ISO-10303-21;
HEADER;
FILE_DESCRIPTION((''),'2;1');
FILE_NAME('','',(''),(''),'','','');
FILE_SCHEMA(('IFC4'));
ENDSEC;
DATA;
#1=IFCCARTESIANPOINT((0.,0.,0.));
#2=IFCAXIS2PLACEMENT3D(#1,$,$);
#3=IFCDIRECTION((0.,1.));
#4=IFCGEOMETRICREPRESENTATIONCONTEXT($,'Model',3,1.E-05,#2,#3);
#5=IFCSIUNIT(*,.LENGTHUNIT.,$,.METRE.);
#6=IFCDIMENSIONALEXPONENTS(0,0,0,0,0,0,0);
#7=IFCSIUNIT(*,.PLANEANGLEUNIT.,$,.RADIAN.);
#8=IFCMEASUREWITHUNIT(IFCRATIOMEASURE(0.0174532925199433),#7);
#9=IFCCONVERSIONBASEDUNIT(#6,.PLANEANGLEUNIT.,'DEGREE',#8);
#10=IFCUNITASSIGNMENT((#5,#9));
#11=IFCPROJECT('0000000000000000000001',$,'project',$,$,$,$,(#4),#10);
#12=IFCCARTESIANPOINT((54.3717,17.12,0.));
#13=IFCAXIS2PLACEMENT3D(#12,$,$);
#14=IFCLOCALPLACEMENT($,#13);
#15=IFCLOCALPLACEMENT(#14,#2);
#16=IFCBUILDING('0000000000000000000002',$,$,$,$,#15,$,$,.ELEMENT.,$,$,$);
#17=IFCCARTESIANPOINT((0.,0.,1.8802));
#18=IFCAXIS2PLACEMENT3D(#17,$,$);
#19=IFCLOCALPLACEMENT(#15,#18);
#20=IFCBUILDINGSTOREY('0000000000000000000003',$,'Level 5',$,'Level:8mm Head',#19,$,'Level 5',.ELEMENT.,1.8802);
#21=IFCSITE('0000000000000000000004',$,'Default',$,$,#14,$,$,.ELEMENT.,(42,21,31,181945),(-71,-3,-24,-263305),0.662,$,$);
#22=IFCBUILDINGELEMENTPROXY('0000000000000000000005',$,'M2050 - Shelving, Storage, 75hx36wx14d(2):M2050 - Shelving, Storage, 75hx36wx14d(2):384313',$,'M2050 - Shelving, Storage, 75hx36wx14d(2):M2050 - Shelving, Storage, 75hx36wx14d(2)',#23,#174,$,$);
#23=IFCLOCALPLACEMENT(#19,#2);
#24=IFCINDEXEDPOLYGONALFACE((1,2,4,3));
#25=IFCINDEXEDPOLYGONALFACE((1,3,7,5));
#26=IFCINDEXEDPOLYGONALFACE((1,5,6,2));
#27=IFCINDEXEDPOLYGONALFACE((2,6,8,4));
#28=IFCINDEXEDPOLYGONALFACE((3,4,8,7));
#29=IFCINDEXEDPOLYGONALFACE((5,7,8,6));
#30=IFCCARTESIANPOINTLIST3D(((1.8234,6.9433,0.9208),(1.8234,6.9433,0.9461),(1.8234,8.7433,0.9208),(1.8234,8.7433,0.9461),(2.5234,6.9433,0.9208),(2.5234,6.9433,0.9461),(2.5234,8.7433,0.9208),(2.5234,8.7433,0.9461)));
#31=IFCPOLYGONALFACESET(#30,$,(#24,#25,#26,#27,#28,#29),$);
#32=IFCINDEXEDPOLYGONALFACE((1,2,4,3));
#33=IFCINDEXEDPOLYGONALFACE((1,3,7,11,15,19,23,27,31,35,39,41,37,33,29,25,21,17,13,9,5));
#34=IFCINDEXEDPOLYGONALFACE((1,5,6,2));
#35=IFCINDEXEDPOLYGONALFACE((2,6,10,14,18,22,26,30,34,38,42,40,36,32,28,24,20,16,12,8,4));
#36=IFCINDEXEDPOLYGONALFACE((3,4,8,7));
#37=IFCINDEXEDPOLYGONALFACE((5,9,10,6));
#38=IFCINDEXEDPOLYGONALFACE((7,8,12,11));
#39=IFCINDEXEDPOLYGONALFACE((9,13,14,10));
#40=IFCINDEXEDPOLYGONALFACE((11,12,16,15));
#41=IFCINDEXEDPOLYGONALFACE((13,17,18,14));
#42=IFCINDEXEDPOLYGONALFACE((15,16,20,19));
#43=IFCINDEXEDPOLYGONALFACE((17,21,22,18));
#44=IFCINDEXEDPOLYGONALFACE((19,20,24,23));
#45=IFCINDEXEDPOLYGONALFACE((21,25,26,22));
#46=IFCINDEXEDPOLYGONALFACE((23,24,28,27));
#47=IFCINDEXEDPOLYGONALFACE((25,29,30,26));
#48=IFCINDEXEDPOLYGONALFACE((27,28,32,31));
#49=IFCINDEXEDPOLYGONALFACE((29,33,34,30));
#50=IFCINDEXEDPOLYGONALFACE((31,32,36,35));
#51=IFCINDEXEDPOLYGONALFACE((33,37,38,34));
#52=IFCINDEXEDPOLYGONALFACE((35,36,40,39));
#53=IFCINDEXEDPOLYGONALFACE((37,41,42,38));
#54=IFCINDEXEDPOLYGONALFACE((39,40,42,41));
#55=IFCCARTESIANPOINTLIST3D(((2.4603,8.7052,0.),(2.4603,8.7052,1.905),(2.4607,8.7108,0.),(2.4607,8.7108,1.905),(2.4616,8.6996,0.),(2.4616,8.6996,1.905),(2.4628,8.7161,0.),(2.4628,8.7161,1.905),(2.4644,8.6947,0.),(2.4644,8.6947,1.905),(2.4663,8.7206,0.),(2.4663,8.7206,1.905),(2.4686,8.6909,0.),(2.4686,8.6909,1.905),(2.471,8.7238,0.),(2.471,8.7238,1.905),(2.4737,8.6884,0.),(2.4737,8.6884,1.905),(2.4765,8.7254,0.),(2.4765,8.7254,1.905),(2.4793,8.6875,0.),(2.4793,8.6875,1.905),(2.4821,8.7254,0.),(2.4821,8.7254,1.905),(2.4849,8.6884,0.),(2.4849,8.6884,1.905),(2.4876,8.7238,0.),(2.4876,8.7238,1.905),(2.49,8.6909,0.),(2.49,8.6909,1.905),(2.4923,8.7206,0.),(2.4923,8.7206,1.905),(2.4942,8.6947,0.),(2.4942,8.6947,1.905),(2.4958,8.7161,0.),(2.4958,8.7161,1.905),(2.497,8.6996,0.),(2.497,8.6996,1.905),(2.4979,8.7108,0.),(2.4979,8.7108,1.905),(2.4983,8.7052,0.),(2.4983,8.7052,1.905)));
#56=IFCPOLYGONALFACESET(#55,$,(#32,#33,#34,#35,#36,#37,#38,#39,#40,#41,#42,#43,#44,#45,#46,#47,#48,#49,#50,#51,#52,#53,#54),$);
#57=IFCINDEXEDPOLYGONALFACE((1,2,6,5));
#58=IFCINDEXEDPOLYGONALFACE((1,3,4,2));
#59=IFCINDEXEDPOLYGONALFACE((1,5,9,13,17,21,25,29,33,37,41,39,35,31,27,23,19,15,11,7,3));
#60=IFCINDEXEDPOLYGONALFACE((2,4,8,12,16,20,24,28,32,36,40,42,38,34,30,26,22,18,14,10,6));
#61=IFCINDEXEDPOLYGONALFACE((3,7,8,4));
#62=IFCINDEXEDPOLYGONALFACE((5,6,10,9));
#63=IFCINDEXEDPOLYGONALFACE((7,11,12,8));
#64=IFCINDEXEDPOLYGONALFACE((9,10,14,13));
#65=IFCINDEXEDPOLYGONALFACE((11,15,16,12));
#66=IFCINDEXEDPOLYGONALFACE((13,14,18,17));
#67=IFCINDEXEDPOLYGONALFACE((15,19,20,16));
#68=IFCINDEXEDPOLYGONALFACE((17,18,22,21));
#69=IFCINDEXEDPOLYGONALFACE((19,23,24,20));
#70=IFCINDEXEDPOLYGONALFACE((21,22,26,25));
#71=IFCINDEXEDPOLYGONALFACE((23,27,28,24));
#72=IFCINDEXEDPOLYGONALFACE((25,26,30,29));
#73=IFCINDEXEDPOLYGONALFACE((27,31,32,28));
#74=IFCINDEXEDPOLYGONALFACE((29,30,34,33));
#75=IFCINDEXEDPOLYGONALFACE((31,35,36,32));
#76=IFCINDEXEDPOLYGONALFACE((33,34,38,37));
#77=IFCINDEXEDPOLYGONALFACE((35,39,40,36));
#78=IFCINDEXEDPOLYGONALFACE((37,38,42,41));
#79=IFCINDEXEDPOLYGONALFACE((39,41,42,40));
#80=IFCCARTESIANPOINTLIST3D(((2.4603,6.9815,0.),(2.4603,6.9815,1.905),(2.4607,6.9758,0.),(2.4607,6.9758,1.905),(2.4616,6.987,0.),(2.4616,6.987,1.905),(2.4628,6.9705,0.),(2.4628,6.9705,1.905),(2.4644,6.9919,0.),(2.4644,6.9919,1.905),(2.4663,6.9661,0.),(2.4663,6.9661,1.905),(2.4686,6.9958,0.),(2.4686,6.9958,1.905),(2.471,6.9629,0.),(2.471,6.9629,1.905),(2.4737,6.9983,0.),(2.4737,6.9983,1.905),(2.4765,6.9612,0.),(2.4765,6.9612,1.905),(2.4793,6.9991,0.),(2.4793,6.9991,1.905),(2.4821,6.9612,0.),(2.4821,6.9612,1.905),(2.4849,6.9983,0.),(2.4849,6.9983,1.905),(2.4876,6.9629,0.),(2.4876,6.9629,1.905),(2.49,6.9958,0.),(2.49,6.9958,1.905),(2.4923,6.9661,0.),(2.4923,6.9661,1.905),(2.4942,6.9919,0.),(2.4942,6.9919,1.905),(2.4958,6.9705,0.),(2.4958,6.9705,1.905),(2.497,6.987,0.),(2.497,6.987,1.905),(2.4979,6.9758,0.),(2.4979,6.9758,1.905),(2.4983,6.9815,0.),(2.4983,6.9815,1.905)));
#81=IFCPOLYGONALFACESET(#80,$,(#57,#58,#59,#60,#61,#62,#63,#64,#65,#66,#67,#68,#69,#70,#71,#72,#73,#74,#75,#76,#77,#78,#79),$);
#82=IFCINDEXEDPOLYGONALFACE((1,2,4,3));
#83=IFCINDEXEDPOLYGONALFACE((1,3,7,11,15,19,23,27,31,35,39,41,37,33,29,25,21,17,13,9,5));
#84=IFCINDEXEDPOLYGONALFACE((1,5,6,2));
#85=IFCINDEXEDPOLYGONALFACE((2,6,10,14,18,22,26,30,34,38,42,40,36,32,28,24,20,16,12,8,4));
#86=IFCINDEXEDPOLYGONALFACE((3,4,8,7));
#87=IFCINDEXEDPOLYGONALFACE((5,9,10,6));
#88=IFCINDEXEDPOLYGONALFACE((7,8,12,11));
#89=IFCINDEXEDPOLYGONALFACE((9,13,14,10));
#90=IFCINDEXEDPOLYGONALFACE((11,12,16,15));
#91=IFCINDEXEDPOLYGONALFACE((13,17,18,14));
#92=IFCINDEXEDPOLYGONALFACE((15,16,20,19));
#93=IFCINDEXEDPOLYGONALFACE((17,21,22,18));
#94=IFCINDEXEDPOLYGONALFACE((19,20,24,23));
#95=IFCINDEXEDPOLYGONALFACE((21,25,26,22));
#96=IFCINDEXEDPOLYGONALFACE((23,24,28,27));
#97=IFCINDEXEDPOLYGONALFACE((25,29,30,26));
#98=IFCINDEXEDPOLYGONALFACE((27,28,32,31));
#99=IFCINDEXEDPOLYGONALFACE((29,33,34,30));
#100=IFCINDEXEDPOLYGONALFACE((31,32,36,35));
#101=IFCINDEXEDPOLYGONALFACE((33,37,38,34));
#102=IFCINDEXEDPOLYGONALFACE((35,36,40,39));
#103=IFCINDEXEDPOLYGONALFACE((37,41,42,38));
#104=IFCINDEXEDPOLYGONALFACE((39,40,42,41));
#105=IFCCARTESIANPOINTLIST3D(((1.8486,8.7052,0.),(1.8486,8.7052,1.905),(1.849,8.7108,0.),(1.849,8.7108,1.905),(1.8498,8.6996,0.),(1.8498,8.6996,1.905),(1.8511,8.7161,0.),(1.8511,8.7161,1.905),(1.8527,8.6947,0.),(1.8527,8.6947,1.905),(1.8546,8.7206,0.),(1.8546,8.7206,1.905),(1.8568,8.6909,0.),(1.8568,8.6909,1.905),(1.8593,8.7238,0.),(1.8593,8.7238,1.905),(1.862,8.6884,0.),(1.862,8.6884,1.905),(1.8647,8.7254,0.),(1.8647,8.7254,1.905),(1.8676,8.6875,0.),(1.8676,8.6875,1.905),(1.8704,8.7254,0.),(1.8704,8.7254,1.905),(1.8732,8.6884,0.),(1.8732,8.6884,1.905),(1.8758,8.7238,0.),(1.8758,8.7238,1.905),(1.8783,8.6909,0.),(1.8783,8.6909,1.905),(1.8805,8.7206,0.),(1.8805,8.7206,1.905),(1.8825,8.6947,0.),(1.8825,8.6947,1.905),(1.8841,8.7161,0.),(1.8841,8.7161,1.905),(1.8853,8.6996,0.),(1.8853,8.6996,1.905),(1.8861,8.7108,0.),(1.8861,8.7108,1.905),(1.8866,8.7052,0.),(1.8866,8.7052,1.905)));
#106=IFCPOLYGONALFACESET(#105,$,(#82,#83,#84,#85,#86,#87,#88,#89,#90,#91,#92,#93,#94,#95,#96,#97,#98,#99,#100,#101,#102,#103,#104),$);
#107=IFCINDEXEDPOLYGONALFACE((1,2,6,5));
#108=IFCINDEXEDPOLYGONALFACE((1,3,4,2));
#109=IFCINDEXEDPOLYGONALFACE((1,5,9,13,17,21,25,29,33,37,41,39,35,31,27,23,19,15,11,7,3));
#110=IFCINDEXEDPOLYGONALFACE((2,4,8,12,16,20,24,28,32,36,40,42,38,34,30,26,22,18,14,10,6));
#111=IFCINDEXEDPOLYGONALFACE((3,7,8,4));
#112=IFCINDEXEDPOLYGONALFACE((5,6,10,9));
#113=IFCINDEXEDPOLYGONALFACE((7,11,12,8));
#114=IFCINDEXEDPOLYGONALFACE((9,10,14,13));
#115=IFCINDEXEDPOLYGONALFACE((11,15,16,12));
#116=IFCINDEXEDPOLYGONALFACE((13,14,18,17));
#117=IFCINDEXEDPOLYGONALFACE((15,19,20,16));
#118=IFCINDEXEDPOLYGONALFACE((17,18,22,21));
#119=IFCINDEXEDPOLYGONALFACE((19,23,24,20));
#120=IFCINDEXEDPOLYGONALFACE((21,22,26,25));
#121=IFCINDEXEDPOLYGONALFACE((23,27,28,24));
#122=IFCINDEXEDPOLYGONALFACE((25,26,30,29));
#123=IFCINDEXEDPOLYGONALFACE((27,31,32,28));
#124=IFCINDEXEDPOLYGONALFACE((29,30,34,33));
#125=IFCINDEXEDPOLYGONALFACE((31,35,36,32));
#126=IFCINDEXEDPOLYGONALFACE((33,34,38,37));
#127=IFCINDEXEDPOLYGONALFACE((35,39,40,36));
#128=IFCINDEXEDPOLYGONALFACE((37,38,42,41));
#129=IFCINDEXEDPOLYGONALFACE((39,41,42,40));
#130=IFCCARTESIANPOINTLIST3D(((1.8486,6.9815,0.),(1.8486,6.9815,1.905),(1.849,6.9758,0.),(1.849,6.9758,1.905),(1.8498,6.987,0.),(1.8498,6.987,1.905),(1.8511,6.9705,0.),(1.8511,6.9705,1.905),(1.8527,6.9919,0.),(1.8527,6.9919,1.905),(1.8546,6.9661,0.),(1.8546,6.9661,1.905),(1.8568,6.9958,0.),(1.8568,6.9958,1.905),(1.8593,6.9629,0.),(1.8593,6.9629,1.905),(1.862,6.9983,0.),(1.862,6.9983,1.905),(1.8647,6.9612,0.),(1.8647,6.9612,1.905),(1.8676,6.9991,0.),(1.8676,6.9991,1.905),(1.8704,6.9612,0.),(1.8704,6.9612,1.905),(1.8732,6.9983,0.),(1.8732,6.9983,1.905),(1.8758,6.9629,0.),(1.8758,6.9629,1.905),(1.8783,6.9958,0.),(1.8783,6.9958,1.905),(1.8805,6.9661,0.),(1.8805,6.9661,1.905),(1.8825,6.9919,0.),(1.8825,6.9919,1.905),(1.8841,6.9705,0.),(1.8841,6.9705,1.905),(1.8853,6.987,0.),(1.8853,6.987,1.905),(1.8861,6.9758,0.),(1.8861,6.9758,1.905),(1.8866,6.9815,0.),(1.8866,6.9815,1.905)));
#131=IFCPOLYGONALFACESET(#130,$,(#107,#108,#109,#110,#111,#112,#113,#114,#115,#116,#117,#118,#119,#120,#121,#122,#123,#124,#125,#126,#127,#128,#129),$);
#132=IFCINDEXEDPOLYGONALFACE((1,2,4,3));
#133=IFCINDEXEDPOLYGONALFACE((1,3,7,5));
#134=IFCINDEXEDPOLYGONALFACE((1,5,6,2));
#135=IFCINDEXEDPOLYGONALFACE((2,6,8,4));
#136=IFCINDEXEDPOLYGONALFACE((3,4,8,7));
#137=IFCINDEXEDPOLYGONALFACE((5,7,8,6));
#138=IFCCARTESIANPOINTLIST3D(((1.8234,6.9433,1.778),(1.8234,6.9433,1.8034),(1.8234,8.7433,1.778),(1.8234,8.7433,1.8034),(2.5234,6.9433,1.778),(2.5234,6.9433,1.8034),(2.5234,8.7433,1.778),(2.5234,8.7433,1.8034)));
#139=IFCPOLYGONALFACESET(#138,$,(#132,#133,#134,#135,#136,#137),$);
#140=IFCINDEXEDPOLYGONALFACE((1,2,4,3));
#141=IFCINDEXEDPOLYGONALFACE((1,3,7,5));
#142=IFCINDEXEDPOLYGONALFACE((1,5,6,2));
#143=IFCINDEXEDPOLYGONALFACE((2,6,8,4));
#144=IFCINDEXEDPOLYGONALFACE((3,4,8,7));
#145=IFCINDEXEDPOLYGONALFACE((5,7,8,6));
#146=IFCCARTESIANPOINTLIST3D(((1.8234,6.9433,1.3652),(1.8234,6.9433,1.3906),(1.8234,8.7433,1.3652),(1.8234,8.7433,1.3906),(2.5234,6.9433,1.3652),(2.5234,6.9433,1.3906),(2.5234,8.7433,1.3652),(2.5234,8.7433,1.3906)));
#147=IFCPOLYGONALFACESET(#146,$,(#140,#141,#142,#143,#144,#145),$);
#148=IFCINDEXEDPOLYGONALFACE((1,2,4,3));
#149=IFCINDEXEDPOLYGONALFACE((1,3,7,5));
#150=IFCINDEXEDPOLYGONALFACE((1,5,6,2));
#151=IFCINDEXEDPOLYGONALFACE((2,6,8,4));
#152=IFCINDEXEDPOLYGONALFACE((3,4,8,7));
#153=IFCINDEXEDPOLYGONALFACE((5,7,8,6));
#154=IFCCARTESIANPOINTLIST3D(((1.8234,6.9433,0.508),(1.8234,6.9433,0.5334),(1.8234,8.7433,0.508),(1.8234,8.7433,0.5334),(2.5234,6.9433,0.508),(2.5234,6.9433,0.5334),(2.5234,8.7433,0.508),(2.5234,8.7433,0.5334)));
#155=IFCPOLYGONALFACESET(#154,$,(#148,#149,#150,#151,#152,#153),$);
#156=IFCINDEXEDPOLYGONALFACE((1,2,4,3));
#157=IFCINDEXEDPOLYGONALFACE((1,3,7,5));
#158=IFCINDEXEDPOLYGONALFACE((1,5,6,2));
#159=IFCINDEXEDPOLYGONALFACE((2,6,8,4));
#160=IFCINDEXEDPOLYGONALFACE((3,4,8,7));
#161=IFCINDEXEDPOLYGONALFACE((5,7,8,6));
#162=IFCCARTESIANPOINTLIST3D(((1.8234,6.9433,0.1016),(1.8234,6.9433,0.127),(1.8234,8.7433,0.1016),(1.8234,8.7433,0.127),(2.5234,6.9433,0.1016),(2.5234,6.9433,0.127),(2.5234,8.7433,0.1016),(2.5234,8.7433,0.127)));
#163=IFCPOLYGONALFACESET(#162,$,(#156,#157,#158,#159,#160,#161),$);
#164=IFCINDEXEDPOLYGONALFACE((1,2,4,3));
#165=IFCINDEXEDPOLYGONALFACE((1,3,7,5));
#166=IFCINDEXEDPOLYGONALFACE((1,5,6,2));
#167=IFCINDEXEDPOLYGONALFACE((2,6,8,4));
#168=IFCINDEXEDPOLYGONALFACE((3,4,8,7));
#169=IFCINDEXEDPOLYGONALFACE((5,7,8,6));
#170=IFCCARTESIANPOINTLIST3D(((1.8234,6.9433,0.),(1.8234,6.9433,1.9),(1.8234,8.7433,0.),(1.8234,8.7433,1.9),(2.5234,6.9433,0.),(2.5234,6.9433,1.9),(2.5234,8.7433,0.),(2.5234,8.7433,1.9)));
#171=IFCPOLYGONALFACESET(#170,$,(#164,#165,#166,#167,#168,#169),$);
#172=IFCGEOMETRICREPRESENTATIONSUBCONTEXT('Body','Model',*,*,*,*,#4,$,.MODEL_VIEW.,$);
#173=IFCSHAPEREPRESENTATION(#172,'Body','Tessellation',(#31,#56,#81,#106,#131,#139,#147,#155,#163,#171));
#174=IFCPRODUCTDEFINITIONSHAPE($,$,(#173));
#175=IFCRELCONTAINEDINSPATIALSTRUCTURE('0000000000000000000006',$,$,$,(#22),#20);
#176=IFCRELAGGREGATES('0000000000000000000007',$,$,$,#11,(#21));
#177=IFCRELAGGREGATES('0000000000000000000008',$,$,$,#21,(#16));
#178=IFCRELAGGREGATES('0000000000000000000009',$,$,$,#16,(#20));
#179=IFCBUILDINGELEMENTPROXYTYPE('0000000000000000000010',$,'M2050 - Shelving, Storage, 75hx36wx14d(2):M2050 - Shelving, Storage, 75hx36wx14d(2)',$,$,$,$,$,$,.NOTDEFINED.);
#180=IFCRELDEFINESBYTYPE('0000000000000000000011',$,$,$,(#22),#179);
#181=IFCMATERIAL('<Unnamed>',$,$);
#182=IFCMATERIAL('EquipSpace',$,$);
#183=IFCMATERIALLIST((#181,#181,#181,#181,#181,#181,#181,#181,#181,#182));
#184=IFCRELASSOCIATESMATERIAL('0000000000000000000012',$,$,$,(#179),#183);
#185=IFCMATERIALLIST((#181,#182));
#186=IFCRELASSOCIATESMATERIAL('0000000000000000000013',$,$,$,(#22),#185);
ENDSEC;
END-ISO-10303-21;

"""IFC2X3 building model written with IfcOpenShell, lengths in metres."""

from ifc_helpers import new_model, entity, si_unit, converted_unit, direction, frame, frame_2d, origin, origin_2d_with_axis, place, context, subcontext, project, spatial, rectangle, circle, extrude, source, transform, mapped, material, material_list, type_object, type_shapes, element, save


model = new_model("IFC2X3")

# Units and contexts
model_context = context("Model", 3, precision=1e-05, world=origin(), true_north=direction((0.0, 1.0)))
body_context = subcontext(model_context, "Body", "Model", "MODEL_VIEW")
ifc_project = project(units=[si_unit("LENGTHUNIT", "METRE"), converted_unit("PLANEANGLEUNIT", "DEGREE", entity("IfcRatioMeasure", 0.0174532925199433), si_unit("PLANEANGLEUNIT", "RADIAN"), dimensions=[0, 0, 0, 0, 0, 0, 0])], contexts=[model_context])

# Site, building, storey
site_placement = place(None, frame((54.3717, 17.12, 0.0)))
site = spatial("IfcSite", under=ifc_project, at=site_placement, Name="Default", CompositionType="ELEMENT", RefLatitude=(42, 21, 31, 181945), RefLongitude=(-71, -3, -24, -263305), RefElevation=0.662)
building_placement = place(site_placement, origin())
building = spatial("IfcBuilding", under=site, at=building_placement, CompositionType="ELEMENT")
storey_placement = place(building_placement, frame((0.0, 0.0, 1.8802)))
storey = spatial("IfcBuildingStorey", under=building, at=storey_placement, Name="Level 5", ObjectType="Level:8mm Head", LongName="Level 5", CompositionType="ELEMENT", Elevation=1.8802)

# Building element proxy
ifc_material_1 = material(Name="<Unnamed>")
ifc_material_2 = material(Name="EquipSpace")
ifc_material_list_1 = material_list([ifc_material_1, ifc_material_1, ifc_material_1, ifc_material_1, ifc_material_1, ifc_material_1, ifc_material_1, ifc_material_1, ifc_material_1, ifc_material_2])
building_element_proxy_type = type_object("IfcBuildingElementProxyType", Name="M2050 - Shelving, Storage, 75hx36wx14d(2):M2050 - Shelving, Storage, 75hx36wx14d(2)", PredefinedType="NOTDEFINED", material=ifc_material_list_1)
shared_shape = source(origin(), body_context, "Body", "SweptSolid", [
    extrude(rectangle(XDim=1.8, YDim=0.7, at=origin_2d_with_axis()), frame((0.0, 0.0, 0.9207), z_axis=(0.0, 0.0, 1.0), x_axis=(-1.0, 0.0, 0.0)), (0.0, 0.0, 1.0), 0.0254),
    extrude(circle(Radius=0.0191, at=origin_2d_with_axis()), frame((0.8633, -0.3059, 0.0), z_axis=(0.0, 0.0, 1.0), x_axis=(-1.0, 0.0, 0.0)), (0.0, 0.0, 1.0), 1.905),
    extrude(circle(Radius=0.0191, at=origin_2d_with_axis()), frame((-0.8633, -0.3059, 0.0)), (0.0, 0.0, 1.0), 1.905),
    extrude(circle(Radius=0.0191, at=origin_2d_with_axis()), frame((0.8633, 0.3059, 0.0), z_axis=(0.0, 0.0, 1.0), x_axis=(-1.0, 0.0, 0.0)), (0.0, 0.0, 1.0), 1.905),
    extrude(circle(Radius=0.0191, at=origin_2d_with_axis()), frame((-0.8633, 0.3059, 0.0)), (0.0, 0.0, 1.0), 1.905),
    extrude(rectangle(XDim=1.8, YDim=0.7, at=origin_2d_with_axis()), frame((0.0, 0.0, 1.778), z_axis=(0.0, 0.0, 1.0), x_axis=(-1.0, 0.0, 0.0)), (0.0, 0.0, 1.0), 0.0254),
    extrude(rectangle(XDim=1.8, YDim=0.7, at=origin_2d_with_axis()), frame((0.0, 0.0, 1.3653), z_axis=(0.0, 0.0, 1.0), x_axis=(-1.0, 0.0, 0.0)), (0.0, 0.0, 1.0), 0.0254),
    extrude(rectangle(XDim=1.8, YDim=0.7, at=origin_2d_with_axis()), frame((0.0, 0.0, 0.508), z_axis=(0.0, 0.0, 1.0), x_axis=(-1.0, 0.0, 0.0)), (0.0, 0.0, 1.0), 0.0254),
    extrude(rectangle(XDim=1.8, YDim=0.7, at=origin_2d_with_axis()), frame((0.0, 0.0, 0.1016), z_axis=(0.0, 0.0, 1.0), x_axis=(-1.0, 0.0, 0.0)), (0.0, 0.0, 1.0), 0.0254),
    extrude(rectangle(XDim=0.7, YDim=1.8, at=frame_2d((0.0, 0.18), x_axis=(1.0, 0.0))), frame((-0.18, 0.0, 0.0), z_axis=(0.0, 0.0, 1.0), x_axis=(0.0, -1.0, 0.0)), (0.0, 0.0, 1.0), 1.9),
])
type_shapes(building_element_proxy_type, [shared_shape])
ifc_material_list_2 = material_list([ifc_material_1, ifc_material_2])
proxy_1_placement = place(storey_placement, frame((2.1734, 7.8433, 0.0), z_axis=(0.0, 0.0, 1.0), x_axis=(0.0, 1.0, 0.0)))
element("IfcBuildingElementProxy", 1, at=proxy_1_placement, inside=storey, type_object=building_element_proxy_type, material=ifc_material_list_2, Name="M2050 - Shelving, Storage, 75hx36wx14d(2):M2050 - Shelving, Storage, 75hx36wx14d(2):384313", ObjectType="M2050 - Shelving, Storage, 75hx36wx14d(2):M2050 - Shelving, Storage, 75hx36wx14d(2)", context=body_context, shape_type="MappedRepresentation", body=[
    mapped(shared_shape, transform((0.0, 0.0, 0.0), scale=1.0)),
])

save(model, "model.ifc")
